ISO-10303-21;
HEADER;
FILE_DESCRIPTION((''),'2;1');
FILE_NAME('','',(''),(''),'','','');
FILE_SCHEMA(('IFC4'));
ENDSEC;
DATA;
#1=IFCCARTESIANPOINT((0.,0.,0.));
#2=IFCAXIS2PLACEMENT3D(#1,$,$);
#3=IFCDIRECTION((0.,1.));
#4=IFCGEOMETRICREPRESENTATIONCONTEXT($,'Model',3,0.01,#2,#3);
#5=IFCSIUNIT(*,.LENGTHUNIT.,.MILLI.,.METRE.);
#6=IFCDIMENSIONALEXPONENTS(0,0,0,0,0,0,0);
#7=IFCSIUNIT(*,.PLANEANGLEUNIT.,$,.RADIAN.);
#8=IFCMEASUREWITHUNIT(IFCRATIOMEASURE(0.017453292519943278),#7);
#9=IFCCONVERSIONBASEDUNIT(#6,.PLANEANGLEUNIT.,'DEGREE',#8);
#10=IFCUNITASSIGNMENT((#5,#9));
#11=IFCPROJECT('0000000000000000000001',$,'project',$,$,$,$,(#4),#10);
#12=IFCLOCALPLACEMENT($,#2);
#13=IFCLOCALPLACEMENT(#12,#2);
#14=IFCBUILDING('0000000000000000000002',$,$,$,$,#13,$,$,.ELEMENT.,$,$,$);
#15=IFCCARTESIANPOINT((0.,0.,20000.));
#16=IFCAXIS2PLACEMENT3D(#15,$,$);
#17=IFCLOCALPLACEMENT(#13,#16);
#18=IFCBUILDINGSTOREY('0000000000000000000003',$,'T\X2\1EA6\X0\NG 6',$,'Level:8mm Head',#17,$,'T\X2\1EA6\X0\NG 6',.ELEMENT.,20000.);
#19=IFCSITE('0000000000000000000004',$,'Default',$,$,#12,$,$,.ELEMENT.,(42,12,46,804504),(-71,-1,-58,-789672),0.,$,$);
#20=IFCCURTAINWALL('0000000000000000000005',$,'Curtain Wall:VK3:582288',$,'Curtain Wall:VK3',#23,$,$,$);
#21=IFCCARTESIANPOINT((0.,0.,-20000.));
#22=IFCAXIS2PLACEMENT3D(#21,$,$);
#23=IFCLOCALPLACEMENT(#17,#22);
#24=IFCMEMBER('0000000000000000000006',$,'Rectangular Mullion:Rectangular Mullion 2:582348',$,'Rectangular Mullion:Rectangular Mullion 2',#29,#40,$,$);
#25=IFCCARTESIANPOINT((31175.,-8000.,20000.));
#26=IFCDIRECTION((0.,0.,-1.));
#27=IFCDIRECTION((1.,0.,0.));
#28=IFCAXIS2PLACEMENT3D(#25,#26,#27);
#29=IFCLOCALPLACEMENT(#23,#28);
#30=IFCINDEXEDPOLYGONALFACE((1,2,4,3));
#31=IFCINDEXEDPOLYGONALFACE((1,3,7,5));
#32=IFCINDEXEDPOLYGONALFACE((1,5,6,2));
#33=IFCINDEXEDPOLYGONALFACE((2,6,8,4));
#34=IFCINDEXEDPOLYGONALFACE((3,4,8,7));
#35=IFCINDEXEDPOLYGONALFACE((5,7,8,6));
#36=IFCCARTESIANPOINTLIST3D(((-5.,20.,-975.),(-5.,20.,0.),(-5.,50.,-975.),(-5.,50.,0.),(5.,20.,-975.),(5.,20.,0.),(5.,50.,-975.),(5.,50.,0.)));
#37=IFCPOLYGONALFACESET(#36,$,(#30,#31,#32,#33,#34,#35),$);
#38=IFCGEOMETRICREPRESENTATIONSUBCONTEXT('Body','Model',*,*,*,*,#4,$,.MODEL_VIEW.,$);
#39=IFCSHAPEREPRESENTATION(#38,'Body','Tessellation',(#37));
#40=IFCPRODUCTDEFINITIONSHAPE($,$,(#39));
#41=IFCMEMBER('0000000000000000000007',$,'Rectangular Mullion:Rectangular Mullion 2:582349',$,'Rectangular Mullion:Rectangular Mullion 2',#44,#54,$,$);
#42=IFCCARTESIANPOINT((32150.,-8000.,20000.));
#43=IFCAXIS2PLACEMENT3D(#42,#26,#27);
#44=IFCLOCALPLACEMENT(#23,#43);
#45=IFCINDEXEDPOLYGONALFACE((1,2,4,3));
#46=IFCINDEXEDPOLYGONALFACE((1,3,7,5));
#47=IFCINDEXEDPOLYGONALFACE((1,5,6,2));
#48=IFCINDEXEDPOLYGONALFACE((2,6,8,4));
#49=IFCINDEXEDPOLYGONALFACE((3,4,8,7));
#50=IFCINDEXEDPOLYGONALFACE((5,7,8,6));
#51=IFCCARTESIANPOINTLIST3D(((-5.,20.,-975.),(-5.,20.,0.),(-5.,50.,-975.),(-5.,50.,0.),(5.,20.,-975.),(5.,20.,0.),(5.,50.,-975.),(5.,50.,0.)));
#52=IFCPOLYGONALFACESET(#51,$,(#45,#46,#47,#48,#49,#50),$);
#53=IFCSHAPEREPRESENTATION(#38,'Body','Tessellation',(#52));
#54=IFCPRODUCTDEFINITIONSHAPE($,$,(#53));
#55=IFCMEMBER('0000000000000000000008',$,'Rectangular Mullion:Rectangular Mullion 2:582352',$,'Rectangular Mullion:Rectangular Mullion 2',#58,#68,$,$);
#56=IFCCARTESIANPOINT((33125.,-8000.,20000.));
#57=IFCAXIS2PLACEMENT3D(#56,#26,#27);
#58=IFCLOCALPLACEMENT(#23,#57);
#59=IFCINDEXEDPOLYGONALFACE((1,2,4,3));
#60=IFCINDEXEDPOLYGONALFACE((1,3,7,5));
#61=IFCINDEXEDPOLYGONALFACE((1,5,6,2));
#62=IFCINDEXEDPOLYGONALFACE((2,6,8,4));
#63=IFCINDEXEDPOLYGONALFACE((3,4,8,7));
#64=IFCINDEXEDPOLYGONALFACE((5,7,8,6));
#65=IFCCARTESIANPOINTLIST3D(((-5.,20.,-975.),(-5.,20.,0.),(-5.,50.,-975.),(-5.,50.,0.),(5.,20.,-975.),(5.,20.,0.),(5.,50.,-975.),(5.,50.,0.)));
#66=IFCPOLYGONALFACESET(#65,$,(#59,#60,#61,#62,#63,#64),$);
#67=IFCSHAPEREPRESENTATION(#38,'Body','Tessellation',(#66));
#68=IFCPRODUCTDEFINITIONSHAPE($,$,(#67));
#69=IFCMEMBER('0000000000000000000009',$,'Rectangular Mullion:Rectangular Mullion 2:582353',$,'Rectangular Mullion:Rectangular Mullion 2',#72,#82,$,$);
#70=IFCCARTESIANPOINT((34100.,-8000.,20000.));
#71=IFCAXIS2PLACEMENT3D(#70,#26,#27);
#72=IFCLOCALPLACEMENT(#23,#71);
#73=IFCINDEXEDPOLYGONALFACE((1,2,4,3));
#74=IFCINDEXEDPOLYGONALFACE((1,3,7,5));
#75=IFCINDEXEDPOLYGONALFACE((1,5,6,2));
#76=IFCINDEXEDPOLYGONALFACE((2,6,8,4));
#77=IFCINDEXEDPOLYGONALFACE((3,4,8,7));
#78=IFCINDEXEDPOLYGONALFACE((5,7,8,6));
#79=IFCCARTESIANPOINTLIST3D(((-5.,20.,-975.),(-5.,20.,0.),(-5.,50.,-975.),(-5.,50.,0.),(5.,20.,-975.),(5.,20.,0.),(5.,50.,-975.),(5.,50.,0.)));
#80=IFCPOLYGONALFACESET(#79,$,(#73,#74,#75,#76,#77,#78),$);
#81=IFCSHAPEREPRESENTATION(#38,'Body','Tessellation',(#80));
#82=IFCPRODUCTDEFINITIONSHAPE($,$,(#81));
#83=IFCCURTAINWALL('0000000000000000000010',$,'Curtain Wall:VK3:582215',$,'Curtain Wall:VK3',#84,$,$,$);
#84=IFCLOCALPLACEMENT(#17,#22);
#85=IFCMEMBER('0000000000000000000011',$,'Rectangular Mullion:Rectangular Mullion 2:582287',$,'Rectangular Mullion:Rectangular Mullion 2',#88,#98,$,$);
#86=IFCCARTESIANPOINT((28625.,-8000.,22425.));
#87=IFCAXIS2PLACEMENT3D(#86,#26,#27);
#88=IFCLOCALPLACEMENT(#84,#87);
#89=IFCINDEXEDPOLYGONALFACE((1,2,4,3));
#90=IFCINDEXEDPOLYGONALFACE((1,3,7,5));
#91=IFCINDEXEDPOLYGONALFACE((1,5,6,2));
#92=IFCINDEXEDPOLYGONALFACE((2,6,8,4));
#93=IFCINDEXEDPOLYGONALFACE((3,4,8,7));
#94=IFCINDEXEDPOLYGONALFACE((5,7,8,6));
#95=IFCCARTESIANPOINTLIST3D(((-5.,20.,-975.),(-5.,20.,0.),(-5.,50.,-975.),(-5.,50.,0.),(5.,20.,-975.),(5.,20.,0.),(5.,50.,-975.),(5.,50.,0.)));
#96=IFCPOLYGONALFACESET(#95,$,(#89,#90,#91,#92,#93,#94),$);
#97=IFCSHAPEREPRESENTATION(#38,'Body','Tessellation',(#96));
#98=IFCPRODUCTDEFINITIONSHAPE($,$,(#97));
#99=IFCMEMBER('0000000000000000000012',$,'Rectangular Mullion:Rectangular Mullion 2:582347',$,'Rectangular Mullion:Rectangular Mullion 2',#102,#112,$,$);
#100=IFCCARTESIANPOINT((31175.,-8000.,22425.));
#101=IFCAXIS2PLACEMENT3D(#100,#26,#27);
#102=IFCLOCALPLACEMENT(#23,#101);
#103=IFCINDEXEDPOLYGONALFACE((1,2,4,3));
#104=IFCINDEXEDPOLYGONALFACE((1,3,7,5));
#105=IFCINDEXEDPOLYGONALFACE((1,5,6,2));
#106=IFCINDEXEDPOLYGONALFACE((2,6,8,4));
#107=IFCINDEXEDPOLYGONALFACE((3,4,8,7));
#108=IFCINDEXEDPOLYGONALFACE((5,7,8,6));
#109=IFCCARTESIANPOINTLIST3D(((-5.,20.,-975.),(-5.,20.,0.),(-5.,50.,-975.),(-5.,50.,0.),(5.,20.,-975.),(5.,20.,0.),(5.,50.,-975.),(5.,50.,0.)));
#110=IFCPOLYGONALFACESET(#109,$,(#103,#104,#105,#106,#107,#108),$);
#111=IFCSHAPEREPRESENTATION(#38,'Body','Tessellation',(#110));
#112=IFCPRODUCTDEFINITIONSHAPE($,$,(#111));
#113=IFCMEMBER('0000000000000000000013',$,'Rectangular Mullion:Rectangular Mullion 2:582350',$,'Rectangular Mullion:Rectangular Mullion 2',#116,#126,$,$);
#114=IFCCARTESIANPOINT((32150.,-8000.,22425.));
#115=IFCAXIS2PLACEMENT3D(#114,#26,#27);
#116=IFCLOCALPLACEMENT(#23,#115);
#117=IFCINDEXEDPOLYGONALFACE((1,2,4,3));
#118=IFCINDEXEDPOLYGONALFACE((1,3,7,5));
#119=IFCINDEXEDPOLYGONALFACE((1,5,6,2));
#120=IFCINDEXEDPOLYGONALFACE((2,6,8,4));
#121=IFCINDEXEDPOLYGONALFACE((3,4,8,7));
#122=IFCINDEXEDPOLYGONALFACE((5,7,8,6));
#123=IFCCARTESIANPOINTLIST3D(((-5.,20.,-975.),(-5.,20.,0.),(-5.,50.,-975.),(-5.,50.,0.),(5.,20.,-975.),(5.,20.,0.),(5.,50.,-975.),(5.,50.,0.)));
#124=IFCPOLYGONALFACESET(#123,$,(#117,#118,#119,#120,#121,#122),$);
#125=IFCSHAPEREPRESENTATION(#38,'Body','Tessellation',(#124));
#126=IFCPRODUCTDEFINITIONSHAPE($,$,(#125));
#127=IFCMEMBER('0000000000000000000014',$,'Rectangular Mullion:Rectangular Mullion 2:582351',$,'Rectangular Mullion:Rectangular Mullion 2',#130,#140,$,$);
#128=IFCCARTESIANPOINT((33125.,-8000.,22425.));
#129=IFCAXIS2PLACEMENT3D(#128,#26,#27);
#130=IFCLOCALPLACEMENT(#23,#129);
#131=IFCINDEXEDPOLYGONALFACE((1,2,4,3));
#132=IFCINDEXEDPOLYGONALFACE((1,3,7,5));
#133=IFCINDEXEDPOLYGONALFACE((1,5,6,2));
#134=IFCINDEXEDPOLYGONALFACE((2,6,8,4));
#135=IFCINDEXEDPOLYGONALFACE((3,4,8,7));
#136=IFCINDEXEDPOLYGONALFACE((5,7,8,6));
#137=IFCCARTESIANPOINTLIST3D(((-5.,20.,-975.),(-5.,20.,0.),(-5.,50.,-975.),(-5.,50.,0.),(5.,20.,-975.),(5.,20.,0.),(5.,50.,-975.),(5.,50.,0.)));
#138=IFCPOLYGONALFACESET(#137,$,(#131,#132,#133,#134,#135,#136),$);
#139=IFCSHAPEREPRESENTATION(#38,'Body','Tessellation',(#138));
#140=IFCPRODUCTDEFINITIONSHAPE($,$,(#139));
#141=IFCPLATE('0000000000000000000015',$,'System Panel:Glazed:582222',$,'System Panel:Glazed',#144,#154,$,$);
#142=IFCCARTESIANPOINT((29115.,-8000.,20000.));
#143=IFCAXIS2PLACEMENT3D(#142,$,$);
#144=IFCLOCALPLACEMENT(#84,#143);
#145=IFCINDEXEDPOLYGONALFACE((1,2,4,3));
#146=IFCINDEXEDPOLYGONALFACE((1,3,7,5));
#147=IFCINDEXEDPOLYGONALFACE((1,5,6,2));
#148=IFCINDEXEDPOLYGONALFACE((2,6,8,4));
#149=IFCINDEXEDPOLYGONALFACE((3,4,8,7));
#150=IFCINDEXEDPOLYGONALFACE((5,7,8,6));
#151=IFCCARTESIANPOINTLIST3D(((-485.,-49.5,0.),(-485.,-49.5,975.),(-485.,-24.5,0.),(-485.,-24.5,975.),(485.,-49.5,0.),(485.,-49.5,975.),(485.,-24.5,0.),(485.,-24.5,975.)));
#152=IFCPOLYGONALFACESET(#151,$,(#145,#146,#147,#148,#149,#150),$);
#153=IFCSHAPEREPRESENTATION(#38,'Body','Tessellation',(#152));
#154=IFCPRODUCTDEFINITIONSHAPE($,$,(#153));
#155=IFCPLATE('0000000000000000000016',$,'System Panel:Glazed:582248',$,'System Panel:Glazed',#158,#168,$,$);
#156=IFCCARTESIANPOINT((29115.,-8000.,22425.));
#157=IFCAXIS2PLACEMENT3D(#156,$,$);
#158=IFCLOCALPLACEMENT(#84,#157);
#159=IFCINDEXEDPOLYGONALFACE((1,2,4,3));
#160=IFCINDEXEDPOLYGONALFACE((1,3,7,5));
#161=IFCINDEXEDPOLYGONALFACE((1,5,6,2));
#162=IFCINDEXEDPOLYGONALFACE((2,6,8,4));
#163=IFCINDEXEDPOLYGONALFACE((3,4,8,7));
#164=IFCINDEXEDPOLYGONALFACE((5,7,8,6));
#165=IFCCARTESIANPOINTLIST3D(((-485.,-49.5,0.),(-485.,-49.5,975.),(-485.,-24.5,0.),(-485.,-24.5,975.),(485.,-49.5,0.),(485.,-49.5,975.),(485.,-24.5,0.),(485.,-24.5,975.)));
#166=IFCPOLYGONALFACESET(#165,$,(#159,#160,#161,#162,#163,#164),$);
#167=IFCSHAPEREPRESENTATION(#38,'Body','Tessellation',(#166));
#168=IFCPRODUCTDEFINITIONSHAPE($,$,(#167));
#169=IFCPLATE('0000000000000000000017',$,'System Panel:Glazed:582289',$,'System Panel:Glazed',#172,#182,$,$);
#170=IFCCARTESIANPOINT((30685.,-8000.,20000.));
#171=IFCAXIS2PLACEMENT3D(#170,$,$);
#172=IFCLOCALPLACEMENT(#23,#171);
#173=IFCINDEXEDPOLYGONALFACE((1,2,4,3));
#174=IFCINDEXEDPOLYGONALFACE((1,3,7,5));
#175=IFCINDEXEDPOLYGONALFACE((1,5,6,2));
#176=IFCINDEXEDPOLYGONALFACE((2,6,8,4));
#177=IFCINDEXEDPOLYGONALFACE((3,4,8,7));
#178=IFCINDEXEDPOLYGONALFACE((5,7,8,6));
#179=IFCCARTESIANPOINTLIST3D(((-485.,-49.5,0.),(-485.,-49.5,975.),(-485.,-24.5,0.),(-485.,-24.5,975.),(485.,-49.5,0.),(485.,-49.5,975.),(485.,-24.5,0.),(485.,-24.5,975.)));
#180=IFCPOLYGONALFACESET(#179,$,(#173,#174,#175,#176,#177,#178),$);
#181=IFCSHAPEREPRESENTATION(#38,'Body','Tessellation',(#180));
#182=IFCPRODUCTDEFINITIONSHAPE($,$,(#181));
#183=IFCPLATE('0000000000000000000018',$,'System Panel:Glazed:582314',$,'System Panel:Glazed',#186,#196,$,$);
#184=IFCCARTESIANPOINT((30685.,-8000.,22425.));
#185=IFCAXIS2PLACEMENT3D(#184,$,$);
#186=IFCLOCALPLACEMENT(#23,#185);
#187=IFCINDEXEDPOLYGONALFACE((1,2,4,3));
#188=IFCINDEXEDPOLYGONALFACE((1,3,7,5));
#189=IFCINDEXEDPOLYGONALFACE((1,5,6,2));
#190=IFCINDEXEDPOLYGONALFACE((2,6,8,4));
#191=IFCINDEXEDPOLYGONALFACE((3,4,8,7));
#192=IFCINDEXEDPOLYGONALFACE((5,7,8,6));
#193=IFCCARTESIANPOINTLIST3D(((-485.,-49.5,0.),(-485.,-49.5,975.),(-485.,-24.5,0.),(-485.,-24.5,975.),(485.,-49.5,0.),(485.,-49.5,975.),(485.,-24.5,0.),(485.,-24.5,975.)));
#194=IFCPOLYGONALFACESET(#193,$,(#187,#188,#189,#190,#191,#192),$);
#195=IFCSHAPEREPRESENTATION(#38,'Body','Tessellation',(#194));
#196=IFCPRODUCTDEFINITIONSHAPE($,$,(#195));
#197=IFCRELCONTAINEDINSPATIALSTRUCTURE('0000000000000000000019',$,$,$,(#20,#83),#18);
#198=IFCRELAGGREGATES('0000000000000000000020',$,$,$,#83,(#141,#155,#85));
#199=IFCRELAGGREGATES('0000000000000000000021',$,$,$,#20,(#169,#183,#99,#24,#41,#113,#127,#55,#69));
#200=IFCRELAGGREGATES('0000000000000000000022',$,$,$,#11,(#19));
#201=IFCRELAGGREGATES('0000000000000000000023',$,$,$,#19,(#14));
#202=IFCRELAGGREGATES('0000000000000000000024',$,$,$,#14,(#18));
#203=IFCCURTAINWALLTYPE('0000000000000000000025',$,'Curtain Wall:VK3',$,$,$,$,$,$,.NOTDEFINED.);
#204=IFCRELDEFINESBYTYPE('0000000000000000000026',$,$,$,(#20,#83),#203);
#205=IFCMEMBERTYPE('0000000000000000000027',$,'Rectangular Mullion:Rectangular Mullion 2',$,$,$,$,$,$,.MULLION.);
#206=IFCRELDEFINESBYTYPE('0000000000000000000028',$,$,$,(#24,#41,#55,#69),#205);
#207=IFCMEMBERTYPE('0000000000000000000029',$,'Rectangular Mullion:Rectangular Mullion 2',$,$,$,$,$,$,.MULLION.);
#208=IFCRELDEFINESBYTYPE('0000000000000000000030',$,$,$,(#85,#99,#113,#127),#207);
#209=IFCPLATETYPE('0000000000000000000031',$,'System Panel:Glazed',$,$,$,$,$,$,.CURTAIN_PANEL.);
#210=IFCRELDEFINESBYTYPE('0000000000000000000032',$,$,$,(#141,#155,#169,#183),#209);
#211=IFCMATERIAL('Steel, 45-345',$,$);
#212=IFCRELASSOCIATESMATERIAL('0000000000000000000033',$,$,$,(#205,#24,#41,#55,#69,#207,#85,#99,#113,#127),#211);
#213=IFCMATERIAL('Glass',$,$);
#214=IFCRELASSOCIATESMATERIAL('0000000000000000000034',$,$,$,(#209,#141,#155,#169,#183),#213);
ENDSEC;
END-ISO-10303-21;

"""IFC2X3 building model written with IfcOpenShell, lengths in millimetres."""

from ifc_helpers import new_model, entity, si_unit, converted_unit, direction, frame, frame_2d, origin, origin_2d_with_axis, place, context, subcontext, project, spatial, rectangle, extrude, source, transform, mapped, material, type_object, type_shapes, element, aggregate, save


model = new_model("IFC2X3")

# Units and contexts
model_context = context("Model", 3, precision=0.01, world=origin(), true_north=direction((0.0, 1.0)))
body_context = subcontext(model_context, "Body", "Model", "MODEL_VIEW")
ifc_project = project(units=[si_unit("LENGTHUNIT", "METRE", prefix="MILLI"), converted_unit("PLANEANGLEUNIT", "DEGREE", entity("IfcRatioMeasure", 0.017453292519943278), si_unit("PLANEANGLEUNIT", "RADIAN"), dimensions=[0, 0, 0, 0, 0, 0, 0])], contexts=[model_context])

# Site, building, storey
site_placement = place(None, origin())
site = spatial("IfcSite", under=ifc_project, at=site_placement, Name="Default", CompositionType="ELEMENT", RefLatitude=(42, 12, 46, 804504), RefLongitude=(-71, -1, -58, -789672), RefElevation=0.0)
building_placement = place(site_placement, origin())
building = spatial("IfcBuilding", under=site, at=building_placement, CompositionType="ELEMENT")
storey_placement = place(building_placement, frame((0.0, 0.0, 20000.0)))
storey = spatial("IfcBuildingStorey", under=building, at=storey_placement, Name="TẦNG 6", ObjectType="Level:8mm Head", LongName="TẦNG 6", CompositionType="ELEMENT", Elevation=20000.0)

# Curtain walls, members
curtain_wall_type = type_object("IfcCurtainWallType", Name="Curtain Wall:VK3", PredefinedType="NOTDEFINED")
curtain_wall_1_placement = place(storey_placement, frame((0.0, 0.0, -20000.0)))
curtain_wall_1 = element("IfcCurtainWall", 1, at=curtain_wall_1_placement, inside=storey, type_object=curtain_wall_type, Name="Curtain Wall:VK3:582288", ObjectType="Curtain Wall:VK3")
ifc_material_1 = material(Name="Steel, 45-345")
member_type_1 = type_object("IfcMemberType", Name="Rectangular Mullion:Rectangular Mullion 2", PredefinedType="MULLION", material=ifc_material_1)
shared_shape_1 = source(origin(), body_context, "Body", "SweptSolid", [
    extrude(rectangle(XDim=30.0, YDim=10.0, at=origin_2d_with_axis()), frame((0.0, 35.0, -975.0), z_axis=(0.0, 0.0, 1.0), x_axis=(0.0, -1.0, 0.0)), (0.0, 0.0, 1.0), 975.0),
])
type_shapes(member_type_1, [shared_shape_1])
member_1_placement = place(curtain_wall_1_placement, frame((31175.0, -8000.0, 20000.0), z_axis=(0.0, 0.0, -1.0), x_axis=(1.0, 0.0, 0.0)))
member_1 = element("IfcMember", 2, at=member_1_placement, type_object=member_type_1, material=ifc_material_1, Name="Rectangular Mullion:Rectangular Mullion 2:582348", ObjectType="Rectangular Mullion:Rectangular Mullion 2", context=body_context, shape_type="MappedRepresentation", body=[
    mapped(shared_shape_1, transform((0.0, 0.0, 0.0), scale=1.0)),
])
member_2_placement = place(curtain_wall_1_placement, frame((32150.0, -8000.0, 20000.0), z_axis=(0.0, 0.0, -1.0), x_axis=(1.0, 0.0, 0.0)))
member_2 = element("IfcMember", 3, at=member_2_placement, type_object=member_type_1, material=ifc_material_1, Name="Rectangular Mullion:Rectangular Mullion 2:582349", ObjectType="Rectangular Mullion:Rectangular Mullion 2", context=body_context, shape_type="MappedRepresentation", body=[
    mapped(shared_shape_1, transform((0.0, 0.0, 0.0), scale=1.0)),
])
member_3_placement = place(curtain_wall_1_placement, frame((33125.0, -8000.0, 20000.0), z_axis=(0.0, 0.0, -1.0), x_axis=(1.0, 0.0, 0.0)))
member_3 = element("IfcMember", 4, at=member_3_placement, type_object=member_type_1, material=ifc_material_1, Name="Rectangular Mullion:Rectangular Mullion 2:582352", ObjectType="Rectangular Mullion:Rectangular Mullion 2", context=body_context, shape_type="MappedRepresentation", body=[
    mapped(shared_shape_1, transform((0.0, 0.0, 0.0), scale=1.0)),
])
member_4_placement = place(curtain_wall_1_placement, frame((34100.0, -8000.0, 20000.0), z_axis=(0.0, 0.0, -1.0), x_axis=(1.0, 0.0, 0.0)))
member_4 = element("IfcMember", 5, at=member_4_placement, type_object=member_type_1, material=ifc_material_1, Name="Rectangular Mullion:Rectangular Mullion 2:582353", ObjectType="Rectangular Mullion:Rectangular Mullion 2", context=body_context, shape_type="MappedRepresentation", body=[
    mapped(shared_shape_1, transform((0.0, 0.0, 0.0), scale=1.0)),
])
curtain_wall_2_placement = place(storey_placement, frame((0.0, 0.0, -20000.0)))
curtain_wall_2 = element("IfcCurtainWall", 6, at=curtain_wall_2_placement, inside=storey, type_object=curtain_wall_type, Name="Curtain Wall:VK3:582215", ObjectType="Curtain Wall:VK3")

# Members
member_type_2 = type_object("IfcMemberType", Name="Rectangular Mullion:Rectangular Mullion 2", PredefinedType="MULLION", material=ifc_material_1)
shared_shape_2 = source(origin(), body_context, "Body", "SweptSolid", [
    extrude(rectangle(XDim=30.0, YDim=10.0, at=origin_2d_with_axis()), frame((0.0, 35.0, -975.0), z_axis=(0.0, 0.0, 1.0), x_axis=(0.0, -1.0, 0.0)), (0.0, 0.0, 1.0), 975.0),
])
type_shapes(member_type_2, [shared_shape_2])
member_5_placement = place(curtain_wall_2_placement, frame((28625.0, -8000.0, 22425.0), z_axis=(0.0, 0.0, -1.0), x_axis=(1.0, 0.0, 0.0)))
member_5 = element("IfcMember", 7, at=member_5_placement, type_object=member_type_2, material=ifc_material_1, Name="Rectangular Mullion:Rectangular Mullion 2:582287", ObjectType="Rectangular Mullion:Rectangular Mullion 2", context=body_context, shape_type="MappedRepresentation", body=[
    mapped(shared_shape_2, transform((0.0, 0.0, 0.0), scale=1.0)),
])
member_6_placement = place(curtain_wall_1_placement, frame((31175.0, -8000.0, 22425.0), z_axis=(0.0, 0.0, -1.0), x_axis=(1.0, 0.0, 0.0)))
member_6 = element("IfcMember", 8, at=member_6_placement, type_object=member_type_2, material=ifc_material_1, Name="Rectangular Mullion:Rectangular Mullion 2:582347", ObjectType="Rectangular Mullion:Rectangular Mullion 2", context=body_context, shape_type="MappedRepresentation", body=[
    mapped(shared_shape_2, transform((0.0, 0.0, 0.0), scale=1.0)),
])
member_7_placement = place(curtain_wall_1_placement, frame((32150.0, -8000.0, 22425.0), z_axis=(0.0, 0.0, -1.0), x_axis=(1.0, 0.0, 0.0)))
member_7 = element("IfcMember", 9, at=member_7_placement, type_object=member_type_2, material=ifc_material_1, Name="Rectangular Mullion:Rectangular Mullion 2:582350", ObjectType="Rectangular Mullion:Rectangular Mullion 2", context=body_context, shape_type="MappedRepresentation", body=[
    mapped(shared_shape_2, transform((0.0, 0.0, 0.0), scale=1.0)),
])
member_8_placement = place(curtain_wall_1_placement, frame((33125.0, -8000.0, 22425.0), z_axis=(0.0, 0.0, -1.0), x_axis=(1.0, 0.0, 0.0)))
member_8 = element("IfcMember", 10, at=member_8_placement, type_object=member_type_2, material=ifc_material_1, Name="Rectangular Mullion:Rectangular Mullion 2:582351", ObjectType="Rectangular Mullion:Rectangular Mullion 2", context=body_context, shape_type="MappedRepresentation", body=[
    mapped(shared_shape_2, transform((0.0, 0.0, 0.0), scale=1.0)),
])

# Plates
ifc_material_2 = material(Name="Glass")
plate_type_1 = type_object("IfcPlateType", Name="System Panel:Glazed", PredefinedType="CURTAIN_PANEL", material=ifc_material_2)
shared_shape_3 = source(origin(), body_context, "Body", "SweptSolid", [
    extrude(rectangle(XDim=25.0, YDim=970.0, at=frame_2d((0.0, 0.0), x_axis=(1.0, 0.0))), frame((0.0, -37.0, 0.0), z_axis=(0.0, 0.0, 1.0), x_axis=(0.0, 1.0, 0.0)), (0.0, 0.0, 1.0), 975.0),
])
type_shapes(plate_type_1, [shared_shape_3])
plate_1_placement = place(curtain_wall_2_placement, frame((29115.0, -8000.0, 20000.0)))
plate_1 = element("IfcPlate", 11, at=plate_1_placement, type_object=plate_type_1, material=ifc_material_2, Name="System Panel:Glazed:582222", ObjectType="System Panel:Glazed", context=body_context, shape_type="MappedRepresentation", body=[
    mapped(shared_shape_3, transform((0.0, 0.0, 0.0), scale=1.0)),
])
plate_2_placement = place(curtain_wall_2_placement, frame((29115.0, -8000.0, 22425.0)))
plate_2 = element("IfcPlate", 12, at=plate_2_placement, type_object=plate_type_1, material=ifc_material_2, Name="System Panel:Glazed:582248", ObjectType="System Panel:Glazed", context=body_context, shape_type="MappedRepresentation", body=[
    mapped(shared_shape_3, transform((0.0, 0.0, 0.0), scale=1.0)),
])
plate_3_placement = place(curtain_wall_1_placement, frame((30685.0, -8000.0, 20000.0)))
plate_3 = element("IfcPlate", 13, at=plate_3_placement, type_object=plate_type_1, material=ifc_material_2, Name="System Panel:Glazed:582289", ObjectType="System Panel:Glazed", context=body_context, shape_type="MappedRepresentation", body=[
    mapped(shared_shape_3, transform((0.0, 0.0, 0.0), scale=1.0)),
])
plate_4_placement = place(curtain_wall_1_placement, frame((30685.0, -8000.0, 22425.0)))
plate_4 = element("IfcPlate", 14, at=plate_4_placement, type_object=plate_type_1, material=ifc_material_2, Name="System Panel:Glazed:582314", ObjectType="System Panel:Glazed", context=body_context, shape_type="MappedRepresentation", body=[
    mapped(shared_shape_3, transform((0.0, 0.0, 0.0), scale=1.0)),
])
aggregate(curtain_wall_2, [plate_1, plate_2, member_5])
aggregate(curtain_wall_1, [plate_3, plate_4, member_6, member_1, member_2, member_7, member_8, member_3, member_4])

save(model, "model.ifc")
